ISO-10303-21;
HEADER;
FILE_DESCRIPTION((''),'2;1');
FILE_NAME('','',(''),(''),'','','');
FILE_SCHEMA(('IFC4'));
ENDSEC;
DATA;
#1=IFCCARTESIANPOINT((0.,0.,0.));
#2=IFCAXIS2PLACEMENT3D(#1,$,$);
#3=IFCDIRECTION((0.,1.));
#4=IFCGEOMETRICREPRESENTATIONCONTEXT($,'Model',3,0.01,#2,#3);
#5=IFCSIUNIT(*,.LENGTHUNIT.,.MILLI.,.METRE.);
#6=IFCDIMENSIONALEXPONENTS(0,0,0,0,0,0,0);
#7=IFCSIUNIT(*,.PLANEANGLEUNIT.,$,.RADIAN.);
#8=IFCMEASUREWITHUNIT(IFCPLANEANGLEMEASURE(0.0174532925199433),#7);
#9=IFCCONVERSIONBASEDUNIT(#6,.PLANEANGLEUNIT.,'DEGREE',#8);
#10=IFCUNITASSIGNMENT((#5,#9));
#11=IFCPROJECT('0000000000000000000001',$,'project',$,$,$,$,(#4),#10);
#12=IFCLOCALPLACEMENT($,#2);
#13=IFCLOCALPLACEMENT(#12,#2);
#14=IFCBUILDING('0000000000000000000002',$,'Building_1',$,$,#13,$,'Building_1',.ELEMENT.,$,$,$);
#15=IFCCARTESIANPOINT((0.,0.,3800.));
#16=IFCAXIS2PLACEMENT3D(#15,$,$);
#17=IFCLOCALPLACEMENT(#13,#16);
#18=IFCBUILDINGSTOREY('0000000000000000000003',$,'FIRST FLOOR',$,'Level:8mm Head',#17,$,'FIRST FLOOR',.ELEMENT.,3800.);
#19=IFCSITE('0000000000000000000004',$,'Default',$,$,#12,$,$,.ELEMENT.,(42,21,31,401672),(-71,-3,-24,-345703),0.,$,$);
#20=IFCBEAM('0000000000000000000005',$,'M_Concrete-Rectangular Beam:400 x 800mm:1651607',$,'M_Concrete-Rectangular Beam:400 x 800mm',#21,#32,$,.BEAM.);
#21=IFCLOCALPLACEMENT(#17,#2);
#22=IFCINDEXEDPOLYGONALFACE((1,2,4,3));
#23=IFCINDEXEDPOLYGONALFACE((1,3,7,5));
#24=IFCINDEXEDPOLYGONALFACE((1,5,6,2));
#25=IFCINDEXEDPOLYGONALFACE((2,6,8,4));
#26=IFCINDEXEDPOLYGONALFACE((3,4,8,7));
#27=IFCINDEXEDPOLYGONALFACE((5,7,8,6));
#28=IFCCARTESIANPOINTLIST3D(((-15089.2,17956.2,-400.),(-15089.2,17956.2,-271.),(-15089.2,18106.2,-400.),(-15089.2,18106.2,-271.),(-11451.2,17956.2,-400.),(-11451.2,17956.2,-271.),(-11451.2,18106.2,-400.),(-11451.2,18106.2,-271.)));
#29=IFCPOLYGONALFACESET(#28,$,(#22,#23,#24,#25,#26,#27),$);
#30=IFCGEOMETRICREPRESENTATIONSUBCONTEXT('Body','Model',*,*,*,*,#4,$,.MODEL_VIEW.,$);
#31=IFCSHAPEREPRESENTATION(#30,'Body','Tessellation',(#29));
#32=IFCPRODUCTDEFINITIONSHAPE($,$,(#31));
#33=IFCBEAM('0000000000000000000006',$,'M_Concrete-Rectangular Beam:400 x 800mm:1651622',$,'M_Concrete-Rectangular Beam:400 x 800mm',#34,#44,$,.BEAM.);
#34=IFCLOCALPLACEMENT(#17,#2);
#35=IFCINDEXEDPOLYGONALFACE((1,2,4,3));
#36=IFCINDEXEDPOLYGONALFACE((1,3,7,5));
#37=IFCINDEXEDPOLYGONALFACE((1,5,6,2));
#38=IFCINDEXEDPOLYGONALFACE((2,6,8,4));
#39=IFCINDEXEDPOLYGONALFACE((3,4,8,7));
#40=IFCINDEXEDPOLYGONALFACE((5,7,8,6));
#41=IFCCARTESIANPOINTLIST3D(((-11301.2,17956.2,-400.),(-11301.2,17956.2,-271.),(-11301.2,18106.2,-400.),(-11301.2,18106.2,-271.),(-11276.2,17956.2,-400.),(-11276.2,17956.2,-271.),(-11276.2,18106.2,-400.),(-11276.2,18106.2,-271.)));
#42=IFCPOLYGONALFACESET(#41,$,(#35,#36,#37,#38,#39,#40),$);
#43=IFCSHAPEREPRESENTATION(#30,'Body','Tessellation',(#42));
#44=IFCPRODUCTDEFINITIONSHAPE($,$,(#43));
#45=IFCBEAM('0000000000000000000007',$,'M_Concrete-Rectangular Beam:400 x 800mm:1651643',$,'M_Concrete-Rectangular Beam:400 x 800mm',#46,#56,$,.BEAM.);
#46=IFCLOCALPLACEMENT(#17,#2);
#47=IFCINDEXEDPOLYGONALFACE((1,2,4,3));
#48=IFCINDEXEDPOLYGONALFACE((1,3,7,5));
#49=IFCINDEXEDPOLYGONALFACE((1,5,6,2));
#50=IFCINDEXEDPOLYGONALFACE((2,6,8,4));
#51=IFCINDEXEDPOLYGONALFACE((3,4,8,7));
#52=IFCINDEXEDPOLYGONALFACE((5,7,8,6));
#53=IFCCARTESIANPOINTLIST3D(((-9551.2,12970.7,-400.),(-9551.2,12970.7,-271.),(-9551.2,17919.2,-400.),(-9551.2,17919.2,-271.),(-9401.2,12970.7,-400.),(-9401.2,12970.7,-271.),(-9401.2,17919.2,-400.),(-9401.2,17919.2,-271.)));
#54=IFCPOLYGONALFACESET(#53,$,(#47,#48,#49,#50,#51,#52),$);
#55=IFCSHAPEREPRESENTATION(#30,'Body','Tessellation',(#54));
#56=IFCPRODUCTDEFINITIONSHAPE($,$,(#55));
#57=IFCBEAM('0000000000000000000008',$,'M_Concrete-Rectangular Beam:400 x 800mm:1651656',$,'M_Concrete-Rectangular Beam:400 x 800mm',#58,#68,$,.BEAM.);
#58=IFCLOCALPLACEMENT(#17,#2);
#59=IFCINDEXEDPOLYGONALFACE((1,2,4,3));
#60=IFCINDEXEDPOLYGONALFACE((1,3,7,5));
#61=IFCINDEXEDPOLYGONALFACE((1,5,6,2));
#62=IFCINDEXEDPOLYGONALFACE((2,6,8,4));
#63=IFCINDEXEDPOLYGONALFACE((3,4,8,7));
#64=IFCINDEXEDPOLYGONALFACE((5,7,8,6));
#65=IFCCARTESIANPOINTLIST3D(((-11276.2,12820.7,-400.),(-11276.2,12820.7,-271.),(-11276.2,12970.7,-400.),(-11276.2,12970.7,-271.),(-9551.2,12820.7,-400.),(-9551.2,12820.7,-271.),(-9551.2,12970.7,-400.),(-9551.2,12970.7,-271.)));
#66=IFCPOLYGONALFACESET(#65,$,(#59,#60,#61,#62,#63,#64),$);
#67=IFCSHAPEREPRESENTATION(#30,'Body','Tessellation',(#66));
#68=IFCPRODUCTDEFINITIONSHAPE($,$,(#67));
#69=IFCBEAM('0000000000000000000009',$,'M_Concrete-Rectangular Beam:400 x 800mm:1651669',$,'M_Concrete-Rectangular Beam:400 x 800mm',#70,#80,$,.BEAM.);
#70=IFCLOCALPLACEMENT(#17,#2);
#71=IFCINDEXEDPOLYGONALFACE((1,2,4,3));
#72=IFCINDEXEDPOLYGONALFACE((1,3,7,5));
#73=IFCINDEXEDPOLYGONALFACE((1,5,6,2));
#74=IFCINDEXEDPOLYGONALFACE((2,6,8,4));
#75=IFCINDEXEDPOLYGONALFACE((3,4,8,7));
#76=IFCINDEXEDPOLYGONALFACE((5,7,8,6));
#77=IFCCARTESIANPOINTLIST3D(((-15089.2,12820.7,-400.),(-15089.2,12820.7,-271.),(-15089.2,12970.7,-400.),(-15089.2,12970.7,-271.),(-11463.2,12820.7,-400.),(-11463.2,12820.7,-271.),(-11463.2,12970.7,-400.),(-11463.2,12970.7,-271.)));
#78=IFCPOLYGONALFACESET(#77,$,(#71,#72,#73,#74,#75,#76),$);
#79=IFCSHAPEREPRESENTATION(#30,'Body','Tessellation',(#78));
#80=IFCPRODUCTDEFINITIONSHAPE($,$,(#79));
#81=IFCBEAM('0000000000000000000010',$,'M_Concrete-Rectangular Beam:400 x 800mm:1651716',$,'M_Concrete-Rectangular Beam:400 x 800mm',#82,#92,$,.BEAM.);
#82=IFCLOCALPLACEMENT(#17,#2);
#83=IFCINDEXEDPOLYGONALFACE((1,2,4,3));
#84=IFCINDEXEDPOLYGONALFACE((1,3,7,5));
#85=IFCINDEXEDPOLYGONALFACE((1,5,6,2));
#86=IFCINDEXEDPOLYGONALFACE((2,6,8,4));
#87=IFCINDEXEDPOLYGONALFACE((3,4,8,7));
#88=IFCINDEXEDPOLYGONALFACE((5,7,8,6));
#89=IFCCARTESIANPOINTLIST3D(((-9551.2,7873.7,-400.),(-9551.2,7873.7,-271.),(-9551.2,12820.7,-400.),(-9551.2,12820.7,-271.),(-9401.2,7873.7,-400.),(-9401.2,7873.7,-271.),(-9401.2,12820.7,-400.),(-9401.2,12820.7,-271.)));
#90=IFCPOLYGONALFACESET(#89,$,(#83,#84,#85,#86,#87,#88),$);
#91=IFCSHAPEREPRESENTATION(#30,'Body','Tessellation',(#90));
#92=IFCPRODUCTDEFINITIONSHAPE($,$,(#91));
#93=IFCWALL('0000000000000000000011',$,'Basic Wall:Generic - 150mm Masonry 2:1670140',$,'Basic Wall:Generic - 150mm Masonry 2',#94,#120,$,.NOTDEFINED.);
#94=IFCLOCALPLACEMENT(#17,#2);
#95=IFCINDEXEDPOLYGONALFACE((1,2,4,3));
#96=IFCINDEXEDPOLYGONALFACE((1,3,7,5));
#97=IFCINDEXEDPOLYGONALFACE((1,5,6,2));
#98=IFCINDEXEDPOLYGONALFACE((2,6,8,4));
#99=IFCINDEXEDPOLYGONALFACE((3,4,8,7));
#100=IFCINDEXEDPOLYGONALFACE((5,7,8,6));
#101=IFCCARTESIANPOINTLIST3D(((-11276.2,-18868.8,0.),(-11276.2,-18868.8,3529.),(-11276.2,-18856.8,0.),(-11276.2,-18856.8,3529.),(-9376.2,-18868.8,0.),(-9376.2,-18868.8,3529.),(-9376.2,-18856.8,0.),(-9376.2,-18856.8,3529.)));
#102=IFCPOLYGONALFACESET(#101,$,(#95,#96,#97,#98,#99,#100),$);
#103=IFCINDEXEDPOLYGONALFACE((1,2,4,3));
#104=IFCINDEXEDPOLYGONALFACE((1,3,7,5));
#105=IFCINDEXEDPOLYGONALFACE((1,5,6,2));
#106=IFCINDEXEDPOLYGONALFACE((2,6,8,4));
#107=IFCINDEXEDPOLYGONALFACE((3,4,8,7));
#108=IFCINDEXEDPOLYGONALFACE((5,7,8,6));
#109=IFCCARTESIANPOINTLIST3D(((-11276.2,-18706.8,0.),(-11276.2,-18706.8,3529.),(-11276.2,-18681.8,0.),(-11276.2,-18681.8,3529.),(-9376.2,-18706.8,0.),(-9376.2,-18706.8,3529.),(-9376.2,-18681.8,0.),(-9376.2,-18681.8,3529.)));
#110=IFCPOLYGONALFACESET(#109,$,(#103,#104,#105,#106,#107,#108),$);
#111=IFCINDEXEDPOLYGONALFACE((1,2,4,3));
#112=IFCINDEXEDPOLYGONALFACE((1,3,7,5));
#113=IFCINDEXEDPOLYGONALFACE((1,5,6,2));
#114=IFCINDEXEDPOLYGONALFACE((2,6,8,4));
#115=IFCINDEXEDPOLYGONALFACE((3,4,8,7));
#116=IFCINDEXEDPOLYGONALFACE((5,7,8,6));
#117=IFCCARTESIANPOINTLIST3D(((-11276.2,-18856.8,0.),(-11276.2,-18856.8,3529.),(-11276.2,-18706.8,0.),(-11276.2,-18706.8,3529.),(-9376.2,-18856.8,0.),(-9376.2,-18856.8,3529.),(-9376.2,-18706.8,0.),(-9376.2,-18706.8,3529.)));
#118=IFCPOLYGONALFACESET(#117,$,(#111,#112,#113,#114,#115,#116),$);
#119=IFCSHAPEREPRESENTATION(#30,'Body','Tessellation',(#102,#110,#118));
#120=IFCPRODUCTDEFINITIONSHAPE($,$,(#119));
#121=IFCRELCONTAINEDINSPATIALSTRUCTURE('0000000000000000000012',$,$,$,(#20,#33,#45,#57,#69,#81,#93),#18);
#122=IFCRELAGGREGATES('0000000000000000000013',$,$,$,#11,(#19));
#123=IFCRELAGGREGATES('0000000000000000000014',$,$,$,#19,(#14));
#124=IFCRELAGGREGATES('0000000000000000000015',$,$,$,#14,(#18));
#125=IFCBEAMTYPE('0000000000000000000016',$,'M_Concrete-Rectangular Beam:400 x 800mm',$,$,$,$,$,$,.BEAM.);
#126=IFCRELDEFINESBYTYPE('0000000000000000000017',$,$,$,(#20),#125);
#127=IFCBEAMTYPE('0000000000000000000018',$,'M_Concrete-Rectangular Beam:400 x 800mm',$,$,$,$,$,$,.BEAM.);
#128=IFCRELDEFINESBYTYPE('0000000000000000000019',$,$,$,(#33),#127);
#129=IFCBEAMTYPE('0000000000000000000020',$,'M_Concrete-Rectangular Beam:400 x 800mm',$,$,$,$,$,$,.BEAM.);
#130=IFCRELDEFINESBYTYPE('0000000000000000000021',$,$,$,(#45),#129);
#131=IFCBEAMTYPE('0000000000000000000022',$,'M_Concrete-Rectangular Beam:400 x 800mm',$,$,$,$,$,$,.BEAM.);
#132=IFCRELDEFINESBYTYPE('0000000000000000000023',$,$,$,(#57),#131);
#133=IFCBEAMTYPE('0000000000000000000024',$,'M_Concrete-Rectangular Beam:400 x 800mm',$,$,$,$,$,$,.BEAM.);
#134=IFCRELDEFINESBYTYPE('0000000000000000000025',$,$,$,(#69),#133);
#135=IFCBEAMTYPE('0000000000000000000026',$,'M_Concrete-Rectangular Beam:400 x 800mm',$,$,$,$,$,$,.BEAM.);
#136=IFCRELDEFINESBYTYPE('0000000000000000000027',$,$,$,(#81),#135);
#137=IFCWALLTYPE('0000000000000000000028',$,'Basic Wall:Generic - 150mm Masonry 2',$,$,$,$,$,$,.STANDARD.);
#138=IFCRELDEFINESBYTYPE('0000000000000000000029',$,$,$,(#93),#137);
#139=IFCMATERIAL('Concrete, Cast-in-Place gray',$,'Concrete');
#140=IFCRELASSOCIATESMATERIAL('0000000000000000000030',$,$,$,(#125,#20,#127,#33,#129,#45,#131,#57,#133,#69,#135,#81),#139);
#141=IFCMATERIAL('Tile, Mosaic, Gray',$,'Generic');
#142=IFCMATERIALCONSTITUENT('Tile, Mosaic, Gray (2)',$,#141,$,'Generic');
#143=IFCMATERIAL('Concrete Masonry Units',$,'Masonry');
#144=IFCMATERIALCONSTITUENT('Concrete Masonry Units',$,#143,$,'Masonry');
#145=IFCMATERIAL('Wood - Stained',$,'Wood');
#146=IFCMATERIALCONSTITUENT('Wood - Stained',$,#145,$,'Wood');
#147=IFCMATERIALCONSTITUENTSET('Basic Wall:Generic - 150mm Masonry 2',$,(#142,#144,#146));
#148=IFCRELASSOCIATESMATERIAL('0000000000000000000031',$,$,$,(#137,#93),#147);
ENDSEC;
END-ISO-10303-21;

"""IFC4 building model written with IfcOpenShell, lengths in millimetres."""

from ifc_helpers import new_model, entity, si_unit, converted_unit, direction, frame, origin, place, context, subcontext, project, spatial, indexed_curve, outline, extrude, source, transform, mapped, material, constituent, constituent_set, type_object, type_shapes, element, save


model = new_model("IFC4")

# Units and contexts
model_context = context("Model", 3, precision=0.01, world=origin(), true_north=direction((0.0, 1.0)))
body_context = subcontext(model_context, "Body", "Model", "MODEL_VIEW")
ifc_project = project(units=[si_unit("LENGTHUNIT", "METRE", prefix="MILLI"), converted_unit("PLANEANGLEUNIT", "DEGREE", entity("IfcPlaneAngleMeasure", 0.0174532925199433), si_unit("PLANEANGLEUNIT", "RADIAN"), dimensions=[0, 0, 0, 0, 0, 0, 0])], contexts=[model_context])

# Site, building, storey
site_placement = place(None, origin())
site = spatial("IfcSite", under=ifc_project, at=site_placement, Name="Default", CompositionType="ELEMENT", RefLatitude=(42, 21, 31, 401672), RefLongitude=(-71, -3, -24, -345703), RefElevation=0.0)
building_placement = place(site_placement, origin())
building = spatial("IfcBuilding", under=site, at=building_placement, Name="Building_1", LongName="Building_1", CompositionType="ELEMENT")
storey_placement = place(building_placement, frame((0.0, 0.0, 3800.0)))
storey = spatial("IfcBuildingStorey", under=building, at=storey_placement, Name="FIRST FLOOR", ObjectType="Level:8mm Head", LongName="FIRST FLOOR", CompositionType="ELEMENT", Elevation=3800.0)

# Beams
ifc_material_1 = material(Name="Concrete, Cast-in-Place gray", Category="Concrete")
beam_type_1 = type_object("IfcBeamType", Name="M_Concrete-Rectangular Beam:400 x 800mm", PredefinedType="BEAM", material=ifc_material_1)
shared_shape_1 = source(origin(), body_context, "Body", "SweptSolid", [
    extrude(outline(indexed_curve([(-64.5, -75.0), (64.5, -75.0), (64.5, 75.0), (-64.5, 75.0), (-64.5, -75.0)], self_intersect=False)), frame((-15089.2, 18031.2, 3464.5), z_axis=(1.0, 0.0, 0.0), x_axis=(0.0, 0.0, -1.0)), (0.0, 0.0, 1.0), 3638.0),
])
type_shapes(beam_type_1, [shared_shape_1])
beam_1_placement = place(storey_placement, frame((0.0, 0.0, -3800.0)))
element("IfcBeam", 1, at=beam_1_placement, inside=storey, type_object=beam_type_1, material=ifc_material_1, Name="M_Concrete-Rectangular Beam:400 x 800mm:1651607", ObjectType="M_Concrete-Rectangular Beam:400 x 800mm", PredefinedType="BEAM", context=body_context, shape_type="MappedRepresentation", body=[
    mapped(shared_shape_1, transform((0.0, 0.0, 0.0), scale=1.0)),
])
beam_type_2 = type_object("IfcBeamType", Name="M_Concrete-Rectangular Beam:400 x 800mm", PredefinedType="BEAM", material=ifc_material_1)
shared_shape_2 = source(origin(), body_context, "Body", "SweptSolid", [
    extrude(outline(indexed_curve([(-64.5, -75.0), (64.5, -75.0), (64.5, 75.0), (-64.5, 75.0), (-64.5, -75.0)], self_intersect=False)), frame((-11301.2, 18031.2, 3464.5), z_axis=(1.0, 0.0, 0.0), x_axis=(0.0, 0.0, -1.0)), (0.0, 0.0, 1.0), 25.0),
])
type_shapes(beam_type_2, [shared_shape_2])
beam_2_placement = place(storey_placement, frame((0.0, 0.0, -3800.0)))
element("IfcBeam", 2, at=beam_2_placement, inside=storey, type_object=beam_type_2, material=ifc_material_1, Name="M_Concrete-Rectangular Beam:400 x 800mm:1651622", ObjectType="M_Concrete-Rectangular Beam:400 x 800mm", PredefinedType="BEAM", context=body_context, shape_type="MappedRepresentation", body=[
    mapped(shared_shape_2, transform((0.0, 0.0, 0.0), scale=1.0)),
])
beam_type_3 = type_object("IfcBeamType", Name="M_Concrete-Rectangular Beam:400 x 800mm", PredefinedType="BEAM", material=ifc_material_1)
shared_shape_3 = source(origin(), body_context, "Body", "SweptSolid", [
    extrude(outline(indexed_curve([(-75.0, -64.5), (75.0, -64.5), (75.0, 64.5), (-75.0, 64.5), (-75.0, -64.5)], self_intersect=False)), frame((-9476.2, 17919.2, 3464.5), z_axis=(0.0, -1.0, 0.0), x_axis=(-1.0, 0.0, 0.0)), (0.0, 0.0, 1.0), 4948.5),
])
type_shapes(beam_type_3, [shared_shape_3])
beam_3_placement = place(storey_placement, frame((0.0, 0.0, -3800.0)))
element("IfcBeam", 3, at=beam_3_placement, inside=storey, type_object=beam_type_3, material=ifc_material_1, Name="M_Concrete-Rectangular Beam:400 x 800mm:1651643", ObjectType="M_Concrete-Rectangular Beam:400 x 800mm", PredefinedType="BEAM", context=body_context, shape_type="MappedRepresentation", body=[
    mapped(shared_shape_3, transform((0.0, 0.0, 0.0), scale=1.0)),
])
beam_type_4 = type_object("IfcBeamType", Name="M_Concrete-Rectangular Beam:400 x 800mm", PredefinedType="BEAM", material=ifc_material_1)
shared_shape_4 = source(origin(), body_context, "Body", "SweptSolid", [
    extrude(outline(indexed_curve([(-64.5, -75.0), (64.5, -75.0), (64.5, 75.0), (-64.5, 75.0), (-64.5, -75.0)], self_intersect=False)), frame((-9551.2, 12895.7, 3464.5), z_axis=(-1.0, 0.0, 0.0), x_axis=(0.0, 0.0, -1.0)), (0.0, 0.0, 1.0), 1725.0),
])
type_shapes(beam_type_4, [shared_shape_4])
beam_4_placement = place(storey_placement, frame((0.0, 0.0, -3800.0)))
element("IfcBeam", 4, at=beam_4_placement, inside=storey, type_object=beam_type_4, material=ifc_material_1, Name="M_Concrete-Rectangular Beam:400 x 800mm:1651656", ObjectType="M_Concrete-Rectangular Beam:400 x 800mm", PredefinedType="BEAM", context=body_context, shape_type="MappedRepresentation", body=[
    mapped(shared_shape_4, transform((0.0, 0.0, 0.0), scale=1.0)),
])
beam_type_5 = type_object("IfcBeamType", Name="M_Concrete-Rectangular Beam:400 x 800mm", PredefinedType="BEAM", material=ifc_material_1)
shared_shape_5 = source(origin(), body_context, "Body", "SweptSolid", [
    extrude(outline(indexed_curve([(-64.5, -75.0), (64.5, -75.0), (64.5, 75.0), (-64.5, 75.0), (-64.5, -75.0)], self_intersect=False)), frame((-11463.2, 12895.7, 3464.5), z_axis=(-1.0, 0.0, 0.0), x_axis=(0.0, 0.0, -1.0)), (0.0, 0.0, 1.0), 3626.0),
])
type_shapes(beam_type_5, [shared_shape_5])
beam_5_placement = place(storey_placement, frame((0.0, 0.0, -3800.0)))
element("IfcBeam", 5, at=beam_5_placement, inside=storey, type_object=beam_type_5, material=ifc_material_1, Name="M_Concrete-Rectangular Beam:400 x 800mm:1651669", ObjectType="M_Concrete-Rectangular Beam:400 x 800mm", PredefinedType="BEAM", context=body_context, shape_type="MappedRepresentation", body=[
    mapped(shared_shape_5, transform((0.0, 0.0, 0.0), scale=1.0)),
])
beam_type_6 = type_object("IfcBeamType", Name="M_Concrete-Rectangular Beam:400 x 800mm", PredefinedType="BEAM", material=ifc_material_1)
shared_shape_6 = source(origin(), body_context, "Body", "SweptSolid", [
    extrude(outline(indexed_curve([(-75.0, -64.5), (75.0, -64.5), (75.0, 64.5), (-75.0, 64.5), (-75.0, -64.5)], self_intersect=False)), frame((-9476.2, 12820.7, 3464.5), z_axis=(0.0, -1.0, 0.0), x_axis=(-1.0, 0.0, 0.0)), (0.0, 0.0, 1.0), 4947.0),
])
type_shapes(beam_type_6, [shared_shape_6])
beam_6_placement = place(storey_placement, frame((0.0, 0.0, -3800.0)))
element("IfcBeam", 6, at=beam_6_placement, inside=storey, type_object=beam_type_6, material=ifc_material_1, Name="M_Concrete-Rectangular Beam:400 x 800mm:1651716", ObjectType="M_Concrete-Rectangular Beam:400 x 800mm", PredefinedType="BEAM", context=body_context, shape_type="MappedRepresentation", body=[
    mapped(shared_shape_6, transform((0.0, 0.0, 0.0), scale=1.0)),
])

# Wall
ifc_material_2 = material(Name="Tile, Mosaic, Gray", Category="Generic")
ifc_constituent_1 = constituent(ifc_material_2, Name="Tile, Mosaic, Gray (2)", Category="Generic")
ifc_material_3 = material(Name="Concrete Masonry Units", Category="Masonry")
ifc_constituent_2 = constituent(ifc_material_3, Name="Concrete Masonry Units", Category="Masonry")
ifc_material_4 = material(Name="Wood - Stained", Category="Wood")
ifc_constituent_3 = constituent(ifc_material_4, Name="Wood - Stained", Category="Wood")
ifc_constituent_set_1 = constituent_set(constituents=[ifc_constituent_1, ifc_constituent_2, ifc_constituent_3], Name="Basic Wall:Generic - 150mm Masonry 2")
wall_type_1 = type_object("IfcWallType", Name="Basic Wall:Generic - 150mm Masonry 2", PredefinedType="STANDARD", material=ifc_constituent_set_1)
wall_1_placement = place(storey_placement, frame((-11276.2, -18775.3, 0.0)))
element("IfcWall", 7, at=wall_1_placement, inside=storey, type_object=wall_type_1, material=ifc_constituent_set_1, Name="Basic Wall:Generic - 150mm Masonry 2:1670140", ObjectType="Basic Wall:Generic - 150mm Masonry 2", PredefinedType="NOTDEFINED", context=body_context, shape_type="SweptSolid", body=[
    extrude(outline(indexed_curve([(-6.0, -950.0), (6.0, -950.0), (6.0, 950.0), (-6.0, 950.0), (-6.0, -950.0)], self_intersect=False)), frame((950.0, -87.5, 0.0), z_axis=(0.0, 0.0, 1.0), x_axis=(0.0, 1.0, 0.0)), (0.0, 0.0, 1.0), 3529.0),
    extrude(outline(indexed_curve([(-12.5, -950.0), (12.5, -950.0), (12.5, 950.0), (-12.5, 950.0), (-12.5, -950.0)], self_intersect=False)), frame((950.0, 81.0, 0.0), z_axis=(0.0, 0.0, 1.0), x_axis=(0.0, -1.0, 0.0)), (0.0, 0.0, 1.0), 3529.0),
    extrude(outline(indexed_curve([(-950.0, -75.0), (950.0, -75.0), (950.0, 75.0), (-950.0, 75.0), (-950.0, -75.0)], self_intersect=False)), frame((950.0, -6.5, 0.0)), (0.0, 0.0, 1.0), 3529.0),
])

save(model, "model.ifc")
